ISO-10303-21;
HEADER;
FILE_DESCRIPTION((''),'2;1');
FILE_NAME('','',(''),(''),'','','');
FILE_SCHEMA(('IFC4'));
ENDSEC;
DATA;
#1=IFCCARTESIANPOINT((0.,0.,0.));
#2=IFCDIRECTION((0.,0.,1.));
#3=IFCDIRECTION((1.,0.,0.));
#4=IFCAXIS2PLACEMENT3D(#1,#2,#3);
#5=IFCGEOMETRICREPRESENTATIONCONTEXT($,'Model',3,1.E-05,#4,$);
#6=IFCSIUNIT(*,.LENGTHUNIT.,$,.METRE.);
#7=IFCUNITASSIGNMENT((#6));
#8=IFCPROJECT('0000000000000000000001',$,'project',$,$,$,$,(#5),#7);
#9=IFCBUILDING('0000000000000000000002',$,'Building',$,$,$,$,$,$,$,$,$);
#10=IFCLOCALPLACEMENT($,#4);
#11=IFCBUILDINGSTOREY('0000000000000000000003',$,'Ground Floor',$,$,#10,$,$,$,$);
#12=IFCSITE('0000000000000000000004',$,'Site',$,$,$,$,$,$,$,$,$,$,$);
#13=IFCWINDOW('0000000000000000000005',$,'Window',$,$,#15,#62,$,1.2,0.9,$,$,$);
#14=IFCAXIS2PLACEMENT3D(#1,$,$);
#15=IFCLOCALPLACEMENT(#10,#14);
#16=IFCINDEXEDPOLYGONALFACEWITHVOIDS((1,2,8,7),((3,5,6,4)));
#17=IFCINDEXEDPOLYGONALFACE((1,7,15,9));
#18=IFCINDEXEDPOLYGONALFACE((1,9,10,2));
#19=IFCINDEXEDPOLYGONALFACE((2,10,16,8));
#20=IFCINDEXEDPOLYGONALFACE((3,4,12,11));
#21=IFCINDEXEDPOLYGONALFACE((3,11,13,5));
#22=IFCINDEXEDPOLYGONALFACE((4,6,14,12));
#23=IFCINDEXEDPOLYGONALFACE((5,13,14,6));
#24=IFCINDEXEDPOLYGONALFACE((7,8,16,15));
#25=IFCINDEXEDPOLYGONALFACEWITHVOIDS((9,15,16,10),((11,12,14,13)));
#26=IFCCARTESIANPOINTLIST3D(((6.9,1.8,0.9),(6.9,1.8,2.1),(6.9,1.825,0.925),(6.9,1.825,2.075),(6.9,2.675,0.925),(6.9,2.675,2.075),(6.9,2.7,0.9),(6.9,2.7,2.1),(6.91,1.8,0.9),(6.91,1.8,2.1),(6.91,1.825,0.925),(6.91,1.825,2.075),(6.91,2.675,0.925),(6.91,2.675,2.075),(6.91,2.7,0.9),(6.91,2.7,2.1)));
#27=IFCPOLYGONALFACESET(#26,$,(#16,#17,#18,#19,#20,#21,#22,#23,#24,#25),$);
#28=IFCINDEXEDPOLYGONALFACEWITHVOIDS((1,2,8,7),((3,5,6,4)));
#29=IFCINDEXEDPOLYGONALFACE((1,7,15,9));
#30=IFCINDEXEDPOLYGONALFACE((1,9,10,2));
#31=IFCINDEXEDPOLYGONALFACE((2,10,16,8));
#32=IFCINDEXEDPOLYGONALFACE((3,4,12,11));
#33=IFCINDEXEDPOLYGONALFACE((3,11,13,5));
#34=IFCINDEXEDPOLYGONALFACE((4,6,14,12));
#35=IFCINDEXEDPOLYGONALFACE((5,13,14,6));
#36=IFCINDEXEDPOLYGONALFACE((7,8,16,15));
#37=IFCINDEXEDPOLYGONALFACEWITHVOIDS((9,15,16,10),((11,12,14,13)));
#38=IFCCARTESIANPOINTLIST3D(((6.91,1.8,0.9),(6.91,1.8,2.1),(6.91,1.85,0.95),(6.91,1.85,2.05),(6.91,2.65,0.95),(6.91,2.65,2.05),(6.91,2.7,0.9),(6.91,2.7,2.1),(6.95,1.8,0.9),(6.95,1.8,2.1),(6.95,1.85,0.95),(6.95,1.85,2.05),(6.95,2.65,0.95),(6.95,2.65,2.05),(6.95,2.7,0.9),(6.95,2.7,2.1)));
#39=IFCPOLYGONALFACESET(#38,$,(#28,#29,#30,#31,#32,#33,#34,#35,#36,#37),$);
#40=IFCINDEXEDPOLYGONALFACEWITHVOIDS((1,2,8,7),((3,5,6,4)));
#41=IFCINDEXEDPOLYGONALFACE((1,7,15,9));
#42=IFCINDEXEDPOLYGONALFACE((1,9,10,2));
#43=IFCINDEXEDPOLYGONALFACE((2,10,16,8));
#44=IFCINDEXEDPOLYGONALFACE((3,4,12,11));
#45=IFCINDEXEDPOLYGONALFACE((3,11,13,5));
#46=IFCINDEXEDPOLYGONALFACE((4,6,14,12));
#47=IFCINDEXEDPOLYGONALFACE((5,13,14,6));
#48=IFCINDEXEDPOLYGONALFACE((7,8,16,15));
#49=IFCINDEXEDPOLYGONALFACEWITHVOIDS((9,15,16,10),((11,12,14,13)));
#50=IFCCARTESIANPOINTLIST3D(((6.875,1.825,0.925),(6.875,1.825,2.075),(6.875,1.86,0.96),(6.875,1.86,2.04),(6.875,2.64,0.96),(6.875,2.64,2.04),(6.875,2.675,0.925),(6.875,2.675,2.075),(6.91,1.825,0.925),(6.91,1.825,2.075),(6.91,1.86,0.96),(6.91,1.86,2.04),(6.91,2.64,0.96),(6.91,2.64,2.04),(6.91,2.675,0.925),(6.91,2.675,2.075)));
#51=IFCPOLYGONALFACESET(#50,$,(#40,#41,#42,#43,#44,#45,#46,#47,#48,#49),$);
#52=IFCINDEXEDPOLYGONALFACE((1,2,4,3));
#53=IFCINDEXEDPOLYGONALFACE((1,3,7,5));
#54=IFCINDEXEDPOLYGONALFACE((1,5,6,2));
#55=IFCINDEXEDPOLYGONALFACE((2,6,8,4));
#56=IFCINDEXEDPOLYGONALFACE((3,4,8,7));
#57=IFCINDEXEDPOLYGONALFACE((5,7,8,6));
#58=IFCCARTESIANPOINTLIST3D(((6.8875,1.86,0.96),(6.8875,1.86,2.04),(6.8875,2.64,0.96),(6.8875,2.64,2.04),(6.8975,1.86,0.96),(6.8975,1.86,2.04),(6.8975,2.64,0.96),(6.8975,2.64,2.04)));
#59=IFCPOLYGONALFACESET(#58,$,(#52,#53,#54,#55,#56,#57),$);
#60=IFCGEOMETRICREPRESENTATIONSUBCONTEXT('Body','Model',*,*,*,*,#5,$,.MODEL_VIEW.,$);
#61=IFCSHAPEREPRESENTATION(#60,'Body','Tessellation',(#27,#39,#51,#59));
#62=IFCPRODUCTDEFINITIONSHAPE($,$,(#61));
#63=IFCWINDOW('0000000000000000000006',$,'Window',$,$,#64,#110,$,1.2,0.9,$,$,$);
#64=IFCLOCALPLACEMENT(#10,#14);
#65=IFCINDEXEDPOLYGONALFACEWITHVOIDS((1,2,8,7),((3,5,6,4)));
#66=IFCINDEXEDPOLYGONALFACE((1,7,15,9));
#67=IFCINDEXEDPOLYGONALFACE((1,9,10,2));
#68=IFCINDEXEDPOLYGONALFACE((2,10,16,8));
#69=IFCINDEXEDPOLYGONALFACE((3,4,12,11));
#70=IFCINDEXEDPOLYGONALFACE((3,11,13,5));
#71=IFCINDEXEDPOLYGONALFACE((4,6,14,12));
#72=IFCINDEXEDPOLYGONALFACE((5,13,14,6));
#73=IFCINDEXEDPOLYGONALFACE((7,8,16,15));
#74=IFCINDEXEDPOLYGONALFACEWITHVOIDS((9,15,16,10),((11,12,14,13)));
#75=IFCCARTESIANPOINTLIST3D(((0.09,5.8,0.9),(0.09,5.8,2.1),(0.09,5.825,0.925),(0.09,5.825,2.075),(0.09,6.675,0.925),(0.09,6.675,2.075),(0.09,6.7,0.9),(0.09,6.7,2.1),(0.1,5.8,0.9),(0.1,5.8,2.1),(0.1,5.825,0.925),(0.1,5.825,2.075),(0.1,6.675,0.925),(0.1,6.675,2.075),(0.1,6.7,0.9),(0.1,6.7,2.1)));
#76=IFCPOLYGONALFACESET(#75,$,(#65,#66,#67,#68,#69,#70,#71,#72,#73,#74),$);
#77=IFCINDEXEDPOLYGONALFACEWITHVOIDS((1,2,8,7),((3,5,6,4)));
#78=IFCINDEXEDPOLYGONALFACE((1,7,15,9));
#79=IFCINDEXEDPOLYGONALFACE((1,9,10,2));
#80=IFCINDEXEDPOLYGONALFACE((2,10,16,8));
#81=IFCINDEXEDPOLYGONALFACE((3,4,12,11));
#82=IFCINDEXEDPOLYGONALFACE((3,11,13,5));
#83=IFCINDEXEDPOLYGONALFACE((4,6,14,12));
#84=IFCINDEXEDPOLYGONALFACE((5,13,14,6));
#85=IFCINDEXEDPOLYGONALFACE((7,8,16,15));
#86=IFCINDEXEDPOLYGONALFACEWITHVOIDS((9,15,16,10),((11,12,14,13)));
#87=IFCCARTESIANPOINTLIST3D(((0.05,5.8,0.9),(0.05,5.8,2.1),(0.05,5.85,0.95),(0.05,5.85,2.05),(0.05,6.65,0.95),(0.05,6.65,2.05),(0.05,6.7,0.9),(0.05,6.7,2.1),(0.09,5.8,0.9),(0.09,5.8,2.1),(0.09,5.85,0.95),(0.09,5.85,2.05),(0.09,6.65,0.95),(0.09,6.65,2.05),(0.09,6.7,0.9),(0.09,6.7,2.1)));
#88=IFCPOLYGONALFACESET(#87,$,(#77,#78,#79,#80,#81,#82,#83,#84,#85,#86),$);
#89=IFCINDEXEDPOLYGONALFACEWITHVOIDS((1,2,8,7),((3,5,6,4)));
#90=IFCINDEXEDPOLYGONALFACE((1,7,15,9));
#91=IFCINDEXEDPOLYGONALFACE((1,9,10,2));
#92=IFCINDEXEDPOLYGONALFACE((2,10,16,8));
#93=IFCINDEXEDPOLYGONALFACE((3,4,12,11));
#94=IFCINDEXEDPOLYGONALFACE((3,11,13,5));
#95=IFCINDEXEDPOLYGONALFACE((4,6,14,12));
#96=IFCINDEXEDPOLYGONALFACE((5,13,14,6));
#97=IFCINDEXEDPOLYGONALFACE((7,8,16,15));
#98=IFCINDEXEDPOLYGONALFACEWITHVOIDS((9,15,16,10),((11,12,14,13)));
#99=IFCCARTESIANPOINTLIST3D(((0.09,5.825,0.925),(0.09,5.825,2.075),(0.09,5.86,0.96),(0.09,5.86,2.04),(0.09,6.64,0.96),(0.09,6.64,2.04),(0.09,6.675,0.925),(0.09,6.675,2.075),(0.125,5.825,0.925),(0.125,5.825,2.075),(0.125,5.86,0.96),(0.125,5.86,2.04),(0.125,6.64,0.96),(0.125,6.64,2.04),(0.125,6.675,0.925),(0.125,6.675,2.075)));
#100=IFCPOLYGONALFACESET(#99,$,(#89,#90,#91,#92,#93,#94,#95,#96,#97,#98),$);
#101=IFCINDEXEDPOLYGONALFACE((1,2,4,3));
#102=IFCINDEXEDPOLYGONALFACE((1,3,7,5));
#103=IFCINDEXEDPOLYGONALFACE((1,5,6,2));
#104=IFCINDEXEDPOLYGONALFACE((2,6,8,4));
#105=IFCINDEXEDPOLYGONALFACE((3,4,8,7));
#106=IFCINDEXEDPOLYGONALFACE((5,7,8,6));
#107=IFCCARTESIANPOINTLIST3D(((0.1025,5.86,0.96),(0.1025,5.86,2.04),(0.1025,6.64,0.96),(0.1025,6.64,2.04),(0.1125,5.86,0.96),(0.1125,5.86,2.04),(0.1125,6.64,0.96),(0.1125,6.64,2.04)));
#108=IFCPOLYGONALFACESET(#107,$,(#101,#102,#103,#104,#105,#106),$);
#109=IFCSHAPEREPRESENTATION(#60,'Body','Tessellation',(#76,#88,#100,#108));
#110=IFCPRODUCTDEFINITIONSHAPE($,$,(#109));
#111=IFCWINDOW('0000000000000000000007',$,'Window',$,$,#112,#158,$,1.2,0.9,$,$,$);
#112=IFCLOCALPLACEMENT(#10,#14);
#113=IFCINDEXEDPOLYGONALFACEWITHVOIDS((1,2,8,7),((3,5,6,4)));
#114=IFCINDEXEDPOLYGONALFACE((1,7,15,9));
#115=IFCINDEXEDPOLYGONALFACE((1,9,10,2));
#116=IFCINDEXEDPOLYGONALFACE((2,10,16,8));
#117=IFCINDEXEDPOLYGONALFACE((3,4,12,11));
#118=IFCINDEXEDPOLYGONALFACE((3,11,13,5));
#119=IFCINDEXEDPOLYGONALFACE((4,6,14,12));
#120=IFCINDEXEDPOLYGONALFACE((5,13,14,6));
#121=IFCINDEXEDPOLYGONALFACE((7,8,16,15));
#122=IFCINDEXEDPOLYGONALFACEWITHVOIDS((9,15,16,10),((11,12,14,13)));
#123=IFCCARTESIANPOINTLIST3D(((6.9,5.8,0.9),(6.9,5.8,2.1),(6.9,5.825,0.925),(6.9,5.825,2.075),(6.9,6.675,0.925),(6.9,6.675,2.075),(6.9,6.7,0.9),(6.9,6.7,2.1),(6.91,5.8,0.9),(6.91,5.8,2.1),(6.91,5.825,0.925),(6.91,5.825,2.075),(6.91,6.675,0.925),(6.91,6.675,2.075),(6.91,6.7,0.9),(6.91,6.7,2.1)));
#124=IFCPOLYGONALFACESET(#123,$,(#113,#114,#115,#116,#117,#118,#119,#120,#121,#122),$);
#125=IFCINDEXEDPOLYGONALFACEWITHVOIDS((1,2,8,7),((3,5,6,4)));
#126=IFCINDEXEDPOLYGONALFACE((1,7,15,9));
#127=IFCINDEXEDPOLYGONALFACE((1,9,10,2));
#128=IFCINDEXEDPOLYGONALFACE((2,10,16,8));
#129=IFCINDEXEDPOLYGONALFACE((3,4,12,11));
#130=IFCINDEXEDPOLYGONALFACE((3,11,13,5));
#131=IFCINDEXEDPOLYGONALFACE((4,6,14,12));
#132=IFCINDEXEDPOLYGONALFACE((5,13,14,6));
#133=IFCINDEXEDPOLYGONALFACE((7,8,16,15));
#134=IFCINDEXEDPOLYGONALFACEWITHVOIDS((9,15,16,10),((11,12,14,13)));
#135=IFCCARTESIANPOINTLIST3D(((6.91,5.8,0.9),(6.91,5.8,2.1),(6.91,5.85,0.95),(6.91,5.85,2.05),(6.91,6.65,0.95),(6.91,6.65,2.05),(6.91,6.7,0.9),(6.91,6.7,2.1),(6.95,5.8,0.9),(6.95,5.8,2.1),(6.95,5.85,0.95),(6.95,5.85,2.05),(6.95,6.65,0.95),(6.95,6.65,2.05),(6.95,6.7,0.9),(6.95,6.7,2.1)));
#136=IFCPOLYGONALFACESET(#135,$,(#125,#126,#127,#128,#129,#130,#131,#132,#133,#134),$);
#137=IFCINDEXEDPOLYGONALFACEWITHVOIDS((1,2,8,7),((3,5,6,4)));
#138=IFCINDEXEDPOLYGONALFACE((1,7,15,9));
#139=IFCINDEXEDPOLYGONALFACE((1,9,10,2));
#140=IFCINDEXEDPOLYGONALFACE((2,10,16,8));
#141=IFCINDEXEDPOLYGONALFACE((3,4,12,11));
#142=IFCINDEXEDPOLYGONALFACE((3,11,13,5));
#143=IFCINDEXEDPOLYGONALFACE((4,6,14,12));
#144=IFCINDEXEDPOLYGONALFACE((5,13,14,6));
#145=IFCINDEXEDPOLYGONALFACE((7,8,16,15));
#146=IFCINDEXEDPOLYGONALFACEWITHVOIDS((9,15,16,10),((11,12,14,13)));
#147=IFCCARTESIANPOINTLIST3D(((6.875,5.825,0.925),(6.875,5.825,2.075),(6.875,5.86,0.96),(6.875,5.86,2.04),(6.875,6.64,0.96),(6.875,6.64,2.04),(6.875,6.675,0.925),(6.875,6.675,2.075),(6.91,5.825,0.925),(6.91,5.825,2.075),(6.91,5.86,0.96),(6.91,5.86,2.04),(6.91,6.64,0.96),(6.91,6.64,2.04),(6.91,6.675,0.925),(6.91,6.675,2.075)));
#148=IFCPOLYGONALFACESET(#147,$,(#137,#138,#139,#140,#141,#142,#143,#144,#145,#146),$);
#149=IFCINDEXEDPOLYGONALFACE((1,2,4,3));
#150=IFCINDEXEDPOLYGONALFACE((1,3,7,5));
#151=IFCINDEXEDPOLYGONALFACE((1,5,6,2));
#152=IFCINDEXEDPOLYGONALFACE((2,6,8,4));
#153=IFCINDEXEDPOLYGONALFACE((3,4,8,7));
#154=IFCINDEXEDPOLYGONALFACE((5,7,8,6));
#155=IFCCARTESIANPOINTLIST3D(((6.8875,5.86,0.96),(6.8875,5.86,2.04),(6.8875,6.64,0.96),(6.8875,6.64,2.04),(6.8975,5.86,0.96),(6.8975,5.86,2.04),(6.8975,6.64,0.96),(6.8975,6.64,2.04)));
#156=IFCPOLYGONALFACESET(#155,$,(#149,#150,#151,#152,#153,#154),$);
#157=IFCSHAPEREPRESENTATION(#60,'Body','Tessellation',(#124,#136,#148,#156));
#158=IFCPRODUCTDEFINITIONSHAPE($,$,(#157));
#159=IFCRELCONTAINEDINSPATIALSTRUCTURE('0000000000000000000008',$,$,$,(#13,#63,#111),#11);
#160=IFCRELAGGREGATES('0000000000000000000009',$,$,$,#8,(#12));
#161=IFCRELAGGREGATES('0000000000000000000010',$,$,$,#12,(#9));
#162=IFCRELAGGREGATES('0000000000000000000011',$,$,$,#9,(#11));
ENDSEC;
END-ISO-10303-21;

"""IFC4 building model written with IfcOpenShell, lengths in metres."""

from ifc_helpers import new_model, si_unit, frame, origin_with_axes, place, context, subcontext, project, spatial, line, indexed_curve, outline, extrude, element, save


model = new_model("IFC4")

# Units and contexts
model_context = context("Model", 3, precision=1e-05, world=origin_with_axes())
body_context = subcontext(model_context, "Body", "Model", "MODEL_VIEW")
ifc_project = project(units=[si_unit("LENGTHUNIT", "METRE")], contexts=[model_context])

# Site, building, storey
site = spatial("IfcSite", under=ifc_project, Name="Site")
building = spatial("IfcBuilding", under=site, Name="Building")
storey_placement = place(None, origin_with_axes())
storey = spatial("IfcBuildingStorey", under=building, at=storey_placement, Name="Ground Floor")

# Windows
for number, where, z_axis, x_axis, name in (
    (1, (7.0, 1.8, 0.9), (0.0, 0.0, 1.0), (0.0, 1.0, 0.0), "Window"),
    (2, (0.0, 6.7, 0.9), (0.0, 0.0, 1.0), (0.0, -1.0, 0.0), "Window"),
    (3, (7.0, 5.8, 0.9), (0.0, 0.0, 1.0), (0.0, 1.0, 0.0), "Window"),
):
    element("IfcWindow", number, at=place(storey_placement, frame(where, z_axis=z_axis, x_axis=x_axis)), inside=storey, Name=name, OverallHeight=1.2, OverallWidth=0.9, context=body_context, shape_type="SweptSolid", body=[
        extrude(outline(indexed_curve([(0.0, 0.0), (0.9, 0.0), (0.9, 1.2), (0.0, 1.2)], segments=[line(1, 2, 3, 4, 1)]), holes=[indexed_curve([(0.025, 0.025), (0.875, 0.025), (0.875, 1.175), (0.025, 1.175)], segments=[line(1, 2, 3, 4, 1)])]), frame((0.0, 0.09, 0.0), z_axis=(0.0, -1.0, 0.0), x_axis=(1.0, 0.0, 0.0)), (0.0, 0.0, -1.0), 0.01),
        extrude(outline(indexed_curve([(0.0, 0.0), (0.9, 0.0), (0.9, 1.2), (0.0, 1.2)], segments=[line(1, 2, 3, 4, 1)]), holes=[indexed_curve([(0.05, 0.05), (0.85, 0.05), (0.85, 1.15), (0.05, 1.15)], segments=[line(1, 2, 3, 4, 1)])]), frame((0.0, 0.05, 0.0), z_axis=(0.0, -1.0, 0.0), x_axis=(1.0, 0.0, 0.0)), (0.0, 0.0, -1.0), 0.04),
        extrude(outline(indexed_curve([(0.0, 0.0), (0.85, 0.0), (0.85, 1.15), (0.0, 1.15)], segments=[line(1, 2, 3, 4, 1)]), holes=[indexed_curve([(0.035, 0.035), (0.815, 0.035), (0.815, 1.115), (0.035, 1.115)], segments=[line(1, 2, 3, 4, 1)])]), frame((0.025, 0.09, 0.025), z_axis=(0.0, -1.0, 0.0), x_axis=(1.0, 0.0, 0.0)), (0.0, 0.0, -1.0), 0.035),
        extrude(outline(indexed_curve([(0.035, 0.035), (0.815, 0.035), (0.815, 1.115), (0.035, 1.115)], segments=[line(1, 2, 3, 4, 1)])), frame((0.025, 0.1025, 0.025), z_axis=(0.0, -1.0, 0.0), x_axis=(1.0, 0.0, 0.0)), (0.0, 0.0, -1.0), 0.01),
    ])

save(model, "model.ifc")
